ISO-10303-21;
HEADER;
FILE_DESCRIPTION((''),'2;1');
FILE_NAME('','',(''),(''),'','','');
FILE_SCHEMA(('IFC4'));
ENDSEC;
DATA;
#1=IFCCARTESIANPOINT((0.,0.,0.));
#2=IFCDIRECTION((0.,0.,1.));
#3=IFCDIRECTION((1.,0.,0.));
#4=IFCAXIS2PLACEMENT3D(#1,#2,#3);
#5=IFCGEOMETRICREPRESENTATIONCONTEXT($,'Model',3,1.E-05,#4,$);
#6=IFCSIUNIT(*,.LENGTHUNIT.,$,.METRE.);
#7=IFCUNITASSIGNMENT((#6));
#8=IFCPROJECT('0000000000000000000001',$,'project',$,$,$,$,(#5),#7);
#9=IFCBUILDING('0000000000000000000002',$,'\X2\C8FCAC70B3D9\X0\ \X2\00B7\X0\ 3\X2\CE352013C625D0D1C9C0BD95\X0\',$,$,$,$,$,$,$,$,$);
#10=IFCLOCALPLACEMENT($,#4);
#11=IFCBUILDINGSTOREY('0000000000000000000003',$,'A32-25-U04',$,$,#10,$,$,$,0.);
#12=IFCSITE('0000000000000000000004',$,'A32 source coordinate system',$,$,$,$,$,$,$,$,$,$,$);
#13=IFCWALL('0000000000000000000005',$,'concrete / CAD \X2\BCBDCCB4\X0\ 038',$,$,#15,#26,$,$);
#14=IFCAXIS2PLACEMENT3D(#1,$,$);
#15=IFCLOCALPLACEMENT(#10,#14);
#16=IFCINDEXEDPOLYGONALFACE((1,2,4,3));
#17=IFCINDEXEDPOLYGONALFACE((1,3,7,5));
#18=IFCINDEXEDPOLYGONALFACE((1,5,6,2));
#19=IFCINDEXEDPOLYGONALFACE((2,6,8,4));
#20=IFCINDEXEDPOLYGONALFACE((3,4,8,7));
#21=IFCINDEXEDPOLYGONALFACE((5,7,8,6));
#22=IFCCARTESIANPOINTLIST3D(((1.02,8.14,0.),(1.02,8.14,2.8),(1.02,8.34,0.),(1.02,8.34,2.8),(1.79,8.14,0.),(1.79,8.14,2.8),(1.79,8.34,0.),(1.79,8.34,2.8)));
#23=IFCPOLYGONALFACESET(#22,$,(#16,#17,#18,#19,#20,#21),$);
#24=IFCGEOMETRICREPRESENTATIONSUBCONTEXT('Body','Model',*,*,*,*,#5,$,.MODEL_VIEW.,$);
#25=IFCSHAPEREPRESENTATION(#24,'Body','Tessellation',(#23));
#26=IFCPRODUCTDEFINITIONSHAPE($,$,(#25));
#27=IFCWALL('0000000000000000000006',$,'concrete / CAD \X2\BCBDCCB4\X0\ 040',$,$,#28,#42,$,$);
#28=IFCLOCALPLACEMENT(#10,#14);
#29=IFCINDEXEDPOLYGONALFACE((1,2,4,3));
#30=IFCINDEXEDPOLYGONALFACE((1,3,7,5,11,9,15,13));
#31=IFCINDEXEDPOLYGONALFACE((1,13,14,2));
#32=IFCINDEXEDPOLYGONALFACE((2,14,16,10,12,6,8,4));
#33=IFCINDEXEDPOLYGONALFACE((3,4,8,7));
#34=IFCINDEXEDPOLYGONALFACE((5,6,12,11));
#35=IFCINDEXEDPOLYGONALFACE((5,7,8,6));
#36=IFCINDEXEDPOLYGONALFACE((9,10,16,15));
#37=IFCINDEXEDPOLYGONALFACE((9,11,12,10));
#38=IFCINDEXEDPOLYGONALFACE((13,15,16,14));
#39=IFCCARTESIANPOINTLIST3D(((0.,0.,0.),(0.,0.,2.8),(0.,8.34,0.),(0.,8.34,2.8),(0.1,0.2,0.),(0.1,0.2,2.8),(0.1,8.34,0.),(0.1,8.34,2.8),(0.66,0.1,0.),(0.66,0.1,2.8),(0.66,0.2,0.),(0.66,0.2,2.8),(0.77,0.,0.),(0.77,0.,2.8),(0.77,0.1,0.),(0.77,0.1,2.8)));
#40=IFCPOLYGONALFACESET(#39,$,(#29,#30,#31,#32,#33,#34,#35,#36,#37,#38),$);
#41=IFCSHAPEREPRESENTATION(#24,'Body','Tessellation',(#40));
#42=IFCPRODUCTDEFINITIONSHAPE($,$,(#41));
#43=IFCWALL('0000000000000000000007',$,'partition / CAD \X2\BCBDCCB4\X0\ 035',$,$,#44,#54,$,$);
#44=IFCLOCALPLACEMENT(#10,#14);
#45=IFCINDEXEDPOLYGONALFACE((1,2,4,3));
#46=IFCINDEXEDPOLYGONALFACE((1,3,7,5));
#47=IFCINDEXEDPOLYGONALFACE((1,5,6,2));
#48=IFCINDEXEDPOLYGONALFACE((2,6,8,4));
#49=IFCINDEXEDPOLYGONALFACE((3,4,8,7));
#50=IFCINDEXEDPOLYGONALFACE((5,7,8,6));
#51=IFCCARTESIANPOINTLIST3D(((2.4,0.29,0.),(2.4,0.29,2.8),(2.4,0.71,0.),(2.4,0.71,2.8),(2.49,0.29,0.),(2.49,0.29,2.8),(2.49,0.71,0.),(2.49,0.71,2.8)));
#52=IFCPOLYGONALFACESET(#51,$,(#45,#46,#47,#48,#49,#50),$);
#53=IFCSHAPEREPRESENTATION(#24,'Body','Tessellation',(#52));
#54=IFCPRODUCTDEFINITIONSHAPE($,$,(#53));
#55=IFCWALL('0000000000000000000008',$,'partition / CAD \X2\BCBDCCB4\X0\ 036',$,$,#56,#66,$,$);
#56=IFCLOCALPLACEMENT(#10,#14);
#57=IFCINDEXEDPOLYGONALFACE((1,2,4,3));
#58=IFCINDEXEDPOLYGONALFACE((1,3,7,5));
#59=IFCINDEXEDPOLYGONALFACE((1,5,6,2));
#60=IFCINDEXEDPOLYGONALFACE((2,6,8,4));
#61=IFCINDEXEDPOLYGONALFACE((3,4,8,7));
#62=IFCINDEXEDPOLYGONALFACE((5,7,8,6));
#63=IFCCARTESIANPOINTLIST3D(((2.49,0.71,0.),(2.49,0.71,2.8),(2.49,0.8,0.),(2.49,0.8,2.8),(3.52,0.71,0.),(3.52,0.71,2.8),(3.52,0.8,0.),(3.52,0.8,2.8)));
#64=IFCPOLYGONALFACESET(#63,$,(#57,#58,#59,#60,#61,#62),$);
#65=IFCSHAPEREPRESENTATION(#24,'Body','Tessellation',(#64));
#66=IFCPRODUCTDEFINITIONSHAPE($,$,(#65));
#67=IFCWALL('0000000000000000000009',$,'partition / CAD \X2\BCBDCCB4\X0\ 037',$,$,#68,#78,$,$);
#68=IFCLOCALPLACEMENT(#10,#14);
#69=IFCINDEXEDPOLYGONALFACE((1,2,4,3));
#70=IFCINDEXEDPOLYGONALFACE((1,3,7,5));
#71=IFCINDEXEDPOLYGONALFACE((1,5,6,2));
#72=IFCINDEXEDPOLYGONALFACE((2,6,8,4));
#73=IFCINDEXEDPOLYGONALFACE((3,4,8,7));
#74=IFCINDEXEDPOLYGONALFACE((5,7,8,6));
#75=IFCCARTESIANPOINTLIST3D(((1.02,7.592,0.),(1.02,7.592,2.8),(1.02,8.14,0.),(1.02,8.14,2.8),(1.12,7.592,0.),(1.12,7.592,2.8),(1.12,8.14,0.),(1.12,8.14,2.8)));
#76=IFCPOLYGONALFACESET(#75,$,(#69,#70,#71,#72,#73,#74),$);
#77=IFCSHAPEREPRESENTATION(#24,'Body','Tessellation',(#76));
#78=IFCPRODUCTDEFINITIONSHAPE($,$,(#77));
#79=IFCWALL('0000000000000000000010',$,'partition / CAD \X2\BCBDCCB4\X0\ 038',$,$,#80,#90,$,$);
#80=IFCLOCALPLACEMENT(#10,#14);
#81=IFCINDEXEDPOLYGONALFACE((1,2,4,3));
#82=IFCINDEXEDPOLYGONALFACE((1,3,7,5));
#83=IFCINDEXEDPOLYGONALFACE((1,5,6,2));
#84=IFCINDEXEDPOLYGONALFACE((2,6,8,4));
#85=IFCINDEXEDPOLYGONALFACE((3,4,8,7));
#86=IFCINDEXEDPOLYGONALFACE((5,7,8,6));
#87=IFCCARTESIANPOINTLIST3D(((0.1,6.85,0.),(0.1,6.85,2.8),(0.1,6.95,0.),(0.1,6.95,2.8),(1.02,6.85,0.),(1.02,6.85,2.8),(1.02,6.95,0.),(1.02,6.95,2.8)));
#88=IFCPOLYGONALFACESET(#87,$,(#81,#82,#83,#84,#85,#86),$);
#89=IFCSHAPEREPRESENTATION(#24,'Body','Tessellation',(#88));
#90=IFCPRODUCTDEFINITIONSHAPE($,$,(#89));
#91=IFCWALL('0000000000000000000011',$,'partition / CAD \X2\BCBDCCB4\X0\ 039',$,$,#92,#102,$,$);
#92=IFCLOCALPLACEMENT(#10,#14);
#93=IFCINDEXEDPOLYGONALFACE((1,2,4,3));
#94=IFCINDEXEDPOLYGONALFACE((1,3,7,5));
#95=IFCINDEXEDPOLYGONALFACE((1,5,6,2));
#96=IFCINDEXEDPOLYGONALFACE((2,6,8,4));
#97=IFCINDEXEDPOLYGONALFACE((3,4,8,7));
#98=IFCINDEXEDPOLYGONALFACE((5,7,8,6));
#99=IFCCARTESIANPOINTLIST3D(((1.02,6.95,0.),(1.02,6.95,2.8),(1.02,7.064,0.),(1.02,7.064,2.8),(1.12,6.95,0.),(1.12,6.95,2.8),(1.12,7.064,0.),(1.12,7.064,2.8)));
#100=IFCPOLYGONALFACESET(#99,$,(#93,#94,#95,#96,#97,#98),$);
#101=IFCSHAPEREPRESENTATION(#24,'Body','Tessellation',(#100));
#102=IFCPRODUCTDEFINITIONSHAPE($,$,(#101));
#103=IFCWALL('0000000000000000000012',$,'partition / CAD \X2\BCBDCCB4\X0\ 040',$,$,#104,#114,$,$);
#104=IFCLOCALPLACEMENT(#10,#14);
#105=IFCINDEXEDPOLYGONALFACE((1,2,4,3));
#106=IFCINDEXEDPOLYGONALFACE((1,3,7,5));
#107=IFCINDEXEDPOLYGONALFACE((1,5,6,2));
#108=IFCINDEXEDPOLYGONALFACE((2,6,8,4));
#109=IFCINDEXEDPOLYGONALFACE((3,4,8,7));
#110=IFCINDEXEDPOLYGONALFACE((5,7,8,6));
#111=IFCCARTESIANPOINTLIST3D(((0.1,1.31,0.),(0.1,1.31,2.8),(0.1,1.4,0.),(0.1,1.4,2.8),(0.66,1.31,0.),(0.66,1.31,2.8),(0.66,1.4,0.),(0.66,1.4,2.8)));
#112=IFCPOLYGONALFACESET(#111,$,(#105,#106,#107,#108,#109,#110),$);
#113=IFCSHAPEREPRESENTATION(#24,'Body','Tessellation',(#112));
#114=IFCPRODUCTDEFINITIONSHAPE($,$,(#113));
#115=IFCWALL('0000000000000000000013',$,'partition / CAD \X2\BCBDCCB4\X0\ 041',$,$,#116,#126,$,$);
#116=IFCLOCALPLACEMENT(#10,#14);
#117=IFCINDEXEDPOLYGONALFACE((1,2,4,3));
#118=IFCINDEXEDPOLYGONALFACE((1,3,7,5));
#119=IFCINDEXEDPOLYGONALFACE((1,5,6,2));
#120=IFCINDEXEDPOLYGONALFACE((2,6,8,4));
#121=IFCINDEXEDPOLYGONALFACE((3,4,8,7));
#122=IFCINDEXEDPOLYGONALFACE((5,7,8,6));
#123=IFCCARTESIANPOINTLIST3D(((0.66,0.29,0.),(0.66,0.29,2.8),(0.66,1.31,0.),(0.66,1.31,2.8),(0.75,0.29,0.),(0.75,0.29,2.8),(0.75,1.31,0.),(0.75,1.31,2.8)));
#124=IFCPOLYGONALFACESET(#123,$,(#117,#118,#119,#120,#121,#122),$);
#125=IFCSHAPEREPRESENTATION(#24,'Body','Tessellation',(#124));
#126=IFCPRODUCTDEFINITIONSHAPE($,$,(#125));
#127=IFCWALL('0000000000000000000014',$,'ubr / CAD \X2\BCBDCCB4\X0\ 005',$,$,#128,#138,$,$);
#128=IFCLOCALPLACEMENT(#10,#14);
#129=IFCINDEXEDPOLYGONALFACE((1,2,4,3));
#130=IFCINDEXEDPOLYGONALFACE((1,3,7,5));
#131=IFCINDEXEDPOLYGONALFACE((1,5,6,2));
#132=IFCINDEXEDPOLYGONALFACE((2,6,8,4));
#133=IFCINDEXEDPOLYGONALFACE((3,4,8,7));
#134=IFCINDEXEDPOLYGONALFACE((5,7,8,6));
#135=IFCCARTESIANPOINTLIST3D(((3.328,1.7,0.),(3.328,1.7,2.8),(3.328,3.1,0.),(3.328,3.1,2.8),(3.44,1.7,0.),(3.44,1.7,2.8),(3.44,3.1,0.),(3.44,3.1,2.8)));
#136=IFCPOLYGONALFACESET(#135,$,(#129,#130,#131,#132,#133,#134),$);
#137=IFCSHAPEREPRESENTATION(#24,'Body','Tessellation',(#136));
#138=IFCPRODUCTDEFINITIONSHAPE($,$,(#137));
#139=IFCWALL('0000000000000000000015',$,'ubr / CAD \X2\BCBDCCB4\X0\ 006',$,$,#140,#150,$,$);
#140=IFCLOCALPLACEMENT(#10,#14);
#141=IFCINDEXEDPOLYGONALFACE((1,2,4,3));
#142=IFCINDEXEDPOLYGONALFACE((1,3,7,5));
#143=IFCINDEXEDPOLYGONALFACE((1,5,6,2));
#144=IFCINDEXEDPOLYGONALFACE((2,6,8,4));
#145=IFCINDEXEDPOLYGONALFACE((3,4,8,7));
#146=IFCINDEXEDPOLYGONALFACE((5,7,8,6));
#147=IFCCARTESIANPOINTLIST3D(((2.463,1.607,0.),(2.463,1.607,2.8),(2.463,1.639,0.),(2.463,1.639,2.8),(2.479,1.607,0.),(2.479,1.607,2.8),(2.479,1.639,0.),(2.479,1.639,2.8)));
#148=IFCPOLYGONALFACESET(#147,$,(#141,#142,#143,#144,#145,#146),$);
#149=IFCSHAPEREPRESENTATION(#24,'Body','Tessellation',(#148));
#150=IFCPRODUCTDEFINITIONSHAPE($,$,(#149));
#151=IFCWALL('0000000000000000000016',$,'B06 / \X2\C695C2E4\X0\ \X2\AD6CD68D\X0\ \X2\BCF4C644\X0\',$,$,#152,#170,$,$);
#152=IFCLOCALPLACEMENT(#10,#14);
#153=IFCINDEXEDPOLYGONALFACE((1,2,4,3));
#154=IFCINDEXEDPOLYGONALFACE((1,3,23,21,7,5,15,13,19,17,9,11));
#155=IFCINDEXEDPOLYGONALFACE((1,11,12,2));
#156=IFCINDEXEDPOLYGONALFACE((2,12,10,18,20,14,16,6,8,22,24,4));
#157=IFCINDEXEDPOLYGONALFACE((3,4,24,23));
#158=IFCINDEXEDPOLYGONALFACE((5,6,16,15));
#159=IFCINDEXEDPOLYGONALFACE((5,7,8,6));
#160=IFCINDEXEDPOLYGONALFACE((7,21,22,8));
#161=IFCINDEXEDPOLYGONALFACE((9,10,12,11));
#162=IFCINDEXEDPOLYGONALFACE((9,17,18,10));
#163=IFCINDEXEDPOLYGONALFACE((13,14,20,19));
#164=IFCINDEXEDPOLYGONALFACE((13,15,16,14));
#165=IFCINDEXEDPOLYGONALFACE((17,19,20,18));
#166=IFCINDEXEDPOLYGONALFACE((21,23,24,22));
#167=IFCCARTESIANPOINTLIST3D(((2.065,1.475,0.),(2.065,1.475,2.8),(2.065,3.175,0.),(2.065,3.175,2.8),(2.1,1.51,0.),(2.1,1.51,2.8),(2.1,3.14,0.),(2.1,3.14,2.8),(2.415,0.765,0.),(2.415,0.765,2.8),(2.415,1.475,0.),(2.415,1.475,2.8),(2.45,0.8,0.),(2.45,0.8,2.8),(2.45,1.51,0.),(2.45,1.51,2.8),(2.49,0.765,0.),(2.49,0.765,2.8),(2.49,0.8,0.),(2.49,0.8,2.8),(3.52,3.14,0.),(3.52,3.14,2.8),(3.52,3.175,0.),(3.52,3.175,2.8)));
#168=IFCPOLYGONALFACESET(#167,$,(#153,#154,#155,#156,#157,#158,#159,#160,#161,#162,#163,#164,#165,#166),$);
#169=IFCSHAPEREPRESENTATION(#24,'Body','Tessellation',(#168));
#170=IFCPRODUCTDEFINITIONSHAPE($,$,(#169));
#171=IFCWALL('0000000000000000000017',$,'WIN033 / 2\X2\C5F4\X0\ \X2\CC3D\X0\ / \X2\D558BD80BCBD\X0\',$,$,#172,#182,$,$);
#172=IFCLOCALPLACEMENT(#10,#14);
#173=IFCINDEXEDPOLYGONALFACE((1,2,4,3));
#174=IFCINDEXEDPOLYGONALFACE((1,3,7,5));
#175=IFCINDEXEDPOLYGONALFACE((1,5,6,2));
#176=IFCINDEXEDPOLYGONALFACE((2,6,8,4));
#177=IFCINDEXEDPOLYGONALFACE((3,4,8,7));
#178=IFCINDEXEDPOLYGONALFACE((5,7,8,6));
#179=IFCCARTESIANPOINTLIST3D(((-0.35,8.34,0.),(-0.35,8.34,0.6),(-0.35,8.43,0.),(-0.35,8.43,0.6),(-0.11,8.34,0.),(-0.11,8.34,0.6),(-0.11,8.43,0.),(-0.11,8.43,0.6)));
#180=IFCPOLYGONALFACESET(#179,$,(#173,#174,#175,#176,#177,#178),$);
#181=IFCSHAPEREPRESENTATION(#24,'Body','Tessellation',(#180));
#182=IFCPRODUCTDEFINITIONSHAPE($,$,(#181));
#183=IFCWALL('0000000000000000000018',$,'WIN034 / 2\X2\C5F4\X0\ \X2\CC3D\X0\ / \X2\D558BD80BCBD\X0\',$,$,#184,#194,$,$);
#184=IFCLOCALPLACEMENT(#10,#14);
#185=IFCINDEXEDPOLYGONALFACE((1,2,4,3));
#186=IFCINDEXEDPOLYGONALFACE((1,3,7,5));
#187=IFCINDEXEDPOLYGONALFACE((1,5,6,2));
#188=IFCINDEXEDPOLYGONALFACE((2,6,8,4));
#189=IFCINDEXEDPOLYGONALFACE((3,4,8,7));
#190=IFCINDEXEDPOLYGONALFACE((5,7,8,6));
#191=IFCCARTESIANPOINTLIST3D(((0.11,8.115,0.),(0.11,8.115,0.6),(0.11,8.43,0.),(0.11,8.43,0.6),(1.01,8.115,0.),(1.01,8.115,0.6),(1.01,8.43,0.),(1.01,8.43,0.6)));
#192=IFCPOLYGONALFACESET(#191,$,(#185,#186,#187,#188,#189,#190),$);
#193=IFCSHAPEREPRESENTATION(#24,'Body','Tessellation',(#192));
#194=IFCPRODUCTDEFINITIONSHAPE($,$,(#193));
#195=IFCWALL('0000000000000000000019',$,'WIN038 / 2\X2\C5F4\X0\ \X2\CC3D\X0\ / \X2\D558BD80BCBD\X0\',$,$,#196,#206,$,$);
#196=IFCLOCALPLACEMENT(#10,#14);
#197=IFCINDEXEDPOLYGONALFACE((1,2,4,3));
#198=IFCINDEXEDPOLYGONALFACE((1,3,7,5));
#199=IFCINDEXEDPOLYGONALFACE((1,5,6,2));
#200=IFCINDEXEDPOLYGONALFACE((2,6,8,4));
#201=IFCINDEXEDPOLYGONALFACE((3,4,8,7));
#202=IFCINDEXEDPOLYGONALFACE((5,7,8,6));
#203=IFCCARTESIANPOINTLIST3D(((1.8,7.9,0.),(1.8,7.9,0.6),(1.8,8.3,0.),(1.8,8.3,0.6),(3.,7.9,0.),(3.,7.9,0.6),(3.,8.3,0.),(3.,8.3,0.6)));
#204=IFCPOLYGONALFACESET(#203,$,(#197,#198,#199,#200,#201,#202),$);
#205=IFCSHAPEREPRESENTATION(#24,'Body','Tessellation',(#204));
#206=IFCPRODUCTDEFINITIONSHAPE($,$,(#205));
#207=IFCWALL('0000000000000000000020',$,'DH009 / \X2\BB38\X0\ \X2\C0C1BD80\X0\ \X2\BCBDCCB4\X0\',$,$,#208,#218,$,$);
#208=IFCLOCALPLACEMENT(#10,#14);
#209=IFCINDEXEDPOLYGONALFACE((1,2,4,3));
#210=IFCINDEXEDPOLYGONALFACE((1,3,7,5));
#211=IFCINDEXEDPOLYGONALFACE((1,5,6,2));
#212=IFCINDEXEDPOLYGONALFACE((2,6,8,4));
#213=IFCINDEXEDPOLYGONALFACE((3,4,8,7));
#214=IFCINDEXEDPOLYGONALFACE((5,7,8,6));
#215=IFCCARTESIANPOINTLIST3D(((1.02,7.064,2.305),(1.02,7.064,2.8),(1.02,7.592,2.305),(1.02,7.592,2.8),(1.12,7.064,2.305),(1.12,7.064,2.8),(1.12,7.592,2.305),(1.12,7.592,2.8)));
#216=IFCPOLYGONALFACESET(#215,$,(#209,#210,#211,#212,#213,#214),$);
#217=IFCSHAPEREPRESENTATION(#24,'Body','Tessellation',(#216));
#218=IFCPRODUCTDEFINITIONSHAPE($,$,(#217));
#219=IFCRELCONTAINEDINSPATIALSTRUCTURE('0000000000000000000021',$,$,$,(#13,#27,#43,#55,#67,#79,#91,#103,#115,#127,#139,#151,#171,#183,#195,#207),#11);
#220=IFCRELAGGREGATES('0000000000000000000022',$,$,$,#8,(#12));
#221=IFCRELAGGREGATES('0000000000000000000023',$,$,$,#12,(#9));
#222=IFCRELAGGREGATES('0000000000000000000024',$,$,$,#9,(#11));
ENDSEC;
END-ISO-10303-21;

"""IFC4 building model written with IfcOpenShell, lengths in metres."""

from ifc_helpers import new_model, si_unit, frame, origin, origin_with_axes, place, context, subcontext, project, spatial, polyline, outline, extrude, element, save


model = new_model("IFC4")

# Units and contexts
model_context = context("Model", 3, precision=1e-05, world=origin_with_axes())
body_context = subcontext(model_context, "Body", "Model", "MODEL_VIEW")
ifc_project = project(units=[si_unit("LENGTHUNIT", "METRE")], contexts=[model_context])

# Site, building, storey
site = spatial("IfcSite", under=ifc_project, Name="A32 source coordinate system")
building = spatial("IfcBuilding", under=site, Name="주거동 · 3층–옥탑지붕")
storey_placement = place(None, origin_with_axes())
storey = spatial("IfcBuildingStorey", under=building, at=storey_placement, Name="A32-25-U04", Elevation=0.0)

# Walls
wall_1_placement = place(storey_placement, origin_with_axes())
element("IfcWall", 1, at=wall_1_placement, inside=storey, Name="concrete / CAD 벽체 038", context=body_context, shape_type="SweptSolid", body=[
    extrude(outline(polyline([(1.02, 8.14), (1.02, 8.34), (1.79, 8.34), (1.79, 8.14), (1.02, 8.14)])), origin(), (0.0, 0.0, 1.0), 2.8),
])
wall_2_placement = place(storey_placement, origin_with_axes())
element("IfcWall", 2, at=wall_2_placement, inside=storey, Name="concrete / CAD 벽체 040", context=body_context, shape_type="SweptSolid", body=[
    extrude(outline(polyline([(-0.1, 8.34), (0.1, 8.34), (0.1, 0.2), (0.66, 0.2), (0.66, 0.1), (0.77, 0.1), (0.77, 0.0), (0.0, 0.0), (0.0, 8.34), (-0.1, 8.34), (-0.1, 8.34)])), origin(), (0.0, 0.0, 1.0), 2.8),
])
wall_3_placement = place(storey_placement, origin_with_axes())
element("IfcWall", 3, at=wall_3_placement, inside=storey, Name="partition / CAD 벽체 035", context=body_context, shape_type="SweptSolid", body=[
    extrude(outline(polyline([(2.49, 0.71), (2.49, 0.29), (2.4, 0.29), (2.4, 0.71), (2.49, 0.71)])), origin(), (0.0, 0.0, 1.0), 2.8),
])
wall_4_placement = place(storey_placement, origin_with_axes())
element("IfcWall", 4, at=wall_4_placement, inside=storey, Name="partition / CAD 벽체 036", context=body_context, shape_type="SweptSolid", body=[
    extrude(outline(polyline([(2.49, 0.8), (3.52, 0.8), (3.52, 0.71), (2.49, 0.71), (2.49, 0.8)])), origin(), (0.0, 0.0, 1.0), 2.8),
])
wall_5_placement = place(storey_placement, origin_with_axes())
element("IfcWall", 5, at=wall_5_placement, inside=storey, Name="partition / CAD 벽체 037", context=body_context, shape_type="SweptSolid", body=[
    extrude(outline(polyline([(1.02, 7.592), (1.02, 8.14), (1.12, 8.14), (1.12, 7.592), (1.02, 7.592)])), origin(), (0.0, 0.0, 1.0), 2.8),
])
wall_6_placement = place(storey_placement, origin_with_axes())
element("IfcWall", 6, at=wall_6_placement, inside=storey, Name="partition / CAD 벽체 038", context=body_context, shape_type="SweptSolid", body=[
    extrude(outline(polyline([(0.1, 6.95), (1.02, 6.95), (1.02, 6.85), (0.1, 6.85), (0.1, 6.95)])), origin(), (0.0, 0.0, 1.0), 2.8),
])
wall_7_placement = place(storey_placement, origin_with_axes())
element("IfcWall", 7, at=wall_7_placement, inside=storey, Name="partition / CAD 벽체 039", context=body_context, shape_type="SweptSolid", body=[
    extrude(outline(polyline([(1.02, 6.95), (1.02, 7.064), (1.12, 7.064), (1.12, 6.95), (1.02, 6.95)])), origin(), (0.0, 0.0, 1.0), 2.8),
])
wall_8_placement = place(storey_placement, origin_with_axes())
element("IfcWall", 8, at=wall_8_placement, inside=storey, Name="partition / CAD 벽체 040", context=body_context, shape_type="SweptSolid", body=[
    extrude(outline(polyline([(0.1, 1.4), (0.66, 1.4), (0.66, 1.31), (0.1, 1.31), (0.1, 1.4)])), origin(), (0.0, 0.0, 1.0), 2.8),
])
wall_9_placement = place(storey_placement, origin_with_axes())
element("IfcWall", 9, at=wall_9_placement, inside=storey, Name="partition / CAD 벽체 041", context=body_context, shape_type="SweptSolid", body=[
    extrude(outline(polyline([(0.75, 1.31), (0.75, 0.29), (0.66, 0.29), (0.66, 1.31), (0.75, 1.31)])), origin(), (0.0, 0.0, 1.0), 2.8),
])
wall_10_placement = place(storey_placement, origin_with_axes())
element("IfcWall", 10, at=wall_10_placement, inside=storey, Name="ubr / CAD 벽체 005", context=body_context, shape_type="SweptSolid", body=[
    extrude(outline(polyline([(3.44, 3.1), (3.44, 1.7), (3.328, 1.7), (3.328, 3.1), (3.44, 3.1)])), origin(), (0.0, 0.0, 1.0), 2.8),
])
wall_11_placement = place(storey_placement, origin_with_axes())
element("IfcWall", 11, at=wall_11_placement, inside=storey, Name="ubr / CAD 벽체 006", context=body_context, shape_type="SweptSolid", body=[
    extrude(outline(polyline([(2.463, 1.639), (2.479, 1.639), (2.479, 1.607), (2.463, 1.607), (2.463, 1.639)])), origin(), (0.0, 0.0, 1.0), 2.8),
])
wall_12_placement = place(storey_placement, origin_with_axes())
element("IfcWall", 12, at=wall_12_placement, inside=storey, Name="B06 / 욕실 구획 보완", context=body_context, shape_type="SweptSolid", body=[
    extrude(outline(polyline([(3.52, 3.14), (2.1, 3.14), (2.1, 1.51), (2.45, 1.51), (2.45, 0.8), (2.49, 0.8), (2.49, 0.765), (2.415, 0.765), (2.415, 1.475), (2.065, 1.475), (2.065, 3.175), (3.52, 3.175), (3.52, 3.14)])), origin(), (0.0, 0.0, 1.0), 2.8),
])
wall_13_placement = place(storey_placement, origin_with_axes())
element("IfcWall", 13, at=wall_13_placement, inside=storey, Name="WIN033 / 2열 창 / 하부벽", context=body_context, shape_type="SweptSolid", body=[
    extrude(outline(polyline([(-0.11, 8.43), (-0.11, 8.34), (-0.35, 8.34), (-0.35, 8.43), (-0.11, 8.43)])), origin(), (0.0, 0.0, 1.0), 0.6),
])
wall_14_placement = place(storey_placement, origin_with_axes())
element("IfcWall", 14, at=wall_14_placement, inside=storey, Name="WIN034 / 2열 창 / 하부벽", context=body_context, shape_type="SweptSolid", body=[
    extrude(outline(polyline([(0.11, 8.115), (0.11, 8.43), (1.01, 8.43), (1.01, 8.115), (0.11, 8.115)])), origin(), (0.0, 0.0, 1.0), 0.6),
])
wall_15_placement = place(storey_placement, origin_with_axes())
element("IfcWall", 15, at=wall_15_placement, inside=storey, Name="WIN038 / 2열 창 / 하부벽", context=body_context, shape_type="SweptSolid", body=[
    extrude(outline(polyline([(1.8, 7.9), (1.8, 8.3), (3.0, 8.3), (3.0, 7.9), (1.8, 7.9)])), origin(), (0.0, 0.0, 1.0), 0.6),
])
wall_16_placement = place(storey_placement, origin_with_axes())
element("IfcWall", 16, at=wall_16_placement, inside=storey, Name="DH009 / 문 상부 벽체", context=body_context, shape_type="SweptSolid", body=[
    extrude(outline(polyline([(1.02, 7.064), (1.02, 7.592), (1.12, 7.592), (1.12, 7.064), (1.02, 7.064)])), frame((0.0, 0.0, 2.305)), (0.0, 0.0, 1.0), 0.495),
])

save(model, "model.ifc")
